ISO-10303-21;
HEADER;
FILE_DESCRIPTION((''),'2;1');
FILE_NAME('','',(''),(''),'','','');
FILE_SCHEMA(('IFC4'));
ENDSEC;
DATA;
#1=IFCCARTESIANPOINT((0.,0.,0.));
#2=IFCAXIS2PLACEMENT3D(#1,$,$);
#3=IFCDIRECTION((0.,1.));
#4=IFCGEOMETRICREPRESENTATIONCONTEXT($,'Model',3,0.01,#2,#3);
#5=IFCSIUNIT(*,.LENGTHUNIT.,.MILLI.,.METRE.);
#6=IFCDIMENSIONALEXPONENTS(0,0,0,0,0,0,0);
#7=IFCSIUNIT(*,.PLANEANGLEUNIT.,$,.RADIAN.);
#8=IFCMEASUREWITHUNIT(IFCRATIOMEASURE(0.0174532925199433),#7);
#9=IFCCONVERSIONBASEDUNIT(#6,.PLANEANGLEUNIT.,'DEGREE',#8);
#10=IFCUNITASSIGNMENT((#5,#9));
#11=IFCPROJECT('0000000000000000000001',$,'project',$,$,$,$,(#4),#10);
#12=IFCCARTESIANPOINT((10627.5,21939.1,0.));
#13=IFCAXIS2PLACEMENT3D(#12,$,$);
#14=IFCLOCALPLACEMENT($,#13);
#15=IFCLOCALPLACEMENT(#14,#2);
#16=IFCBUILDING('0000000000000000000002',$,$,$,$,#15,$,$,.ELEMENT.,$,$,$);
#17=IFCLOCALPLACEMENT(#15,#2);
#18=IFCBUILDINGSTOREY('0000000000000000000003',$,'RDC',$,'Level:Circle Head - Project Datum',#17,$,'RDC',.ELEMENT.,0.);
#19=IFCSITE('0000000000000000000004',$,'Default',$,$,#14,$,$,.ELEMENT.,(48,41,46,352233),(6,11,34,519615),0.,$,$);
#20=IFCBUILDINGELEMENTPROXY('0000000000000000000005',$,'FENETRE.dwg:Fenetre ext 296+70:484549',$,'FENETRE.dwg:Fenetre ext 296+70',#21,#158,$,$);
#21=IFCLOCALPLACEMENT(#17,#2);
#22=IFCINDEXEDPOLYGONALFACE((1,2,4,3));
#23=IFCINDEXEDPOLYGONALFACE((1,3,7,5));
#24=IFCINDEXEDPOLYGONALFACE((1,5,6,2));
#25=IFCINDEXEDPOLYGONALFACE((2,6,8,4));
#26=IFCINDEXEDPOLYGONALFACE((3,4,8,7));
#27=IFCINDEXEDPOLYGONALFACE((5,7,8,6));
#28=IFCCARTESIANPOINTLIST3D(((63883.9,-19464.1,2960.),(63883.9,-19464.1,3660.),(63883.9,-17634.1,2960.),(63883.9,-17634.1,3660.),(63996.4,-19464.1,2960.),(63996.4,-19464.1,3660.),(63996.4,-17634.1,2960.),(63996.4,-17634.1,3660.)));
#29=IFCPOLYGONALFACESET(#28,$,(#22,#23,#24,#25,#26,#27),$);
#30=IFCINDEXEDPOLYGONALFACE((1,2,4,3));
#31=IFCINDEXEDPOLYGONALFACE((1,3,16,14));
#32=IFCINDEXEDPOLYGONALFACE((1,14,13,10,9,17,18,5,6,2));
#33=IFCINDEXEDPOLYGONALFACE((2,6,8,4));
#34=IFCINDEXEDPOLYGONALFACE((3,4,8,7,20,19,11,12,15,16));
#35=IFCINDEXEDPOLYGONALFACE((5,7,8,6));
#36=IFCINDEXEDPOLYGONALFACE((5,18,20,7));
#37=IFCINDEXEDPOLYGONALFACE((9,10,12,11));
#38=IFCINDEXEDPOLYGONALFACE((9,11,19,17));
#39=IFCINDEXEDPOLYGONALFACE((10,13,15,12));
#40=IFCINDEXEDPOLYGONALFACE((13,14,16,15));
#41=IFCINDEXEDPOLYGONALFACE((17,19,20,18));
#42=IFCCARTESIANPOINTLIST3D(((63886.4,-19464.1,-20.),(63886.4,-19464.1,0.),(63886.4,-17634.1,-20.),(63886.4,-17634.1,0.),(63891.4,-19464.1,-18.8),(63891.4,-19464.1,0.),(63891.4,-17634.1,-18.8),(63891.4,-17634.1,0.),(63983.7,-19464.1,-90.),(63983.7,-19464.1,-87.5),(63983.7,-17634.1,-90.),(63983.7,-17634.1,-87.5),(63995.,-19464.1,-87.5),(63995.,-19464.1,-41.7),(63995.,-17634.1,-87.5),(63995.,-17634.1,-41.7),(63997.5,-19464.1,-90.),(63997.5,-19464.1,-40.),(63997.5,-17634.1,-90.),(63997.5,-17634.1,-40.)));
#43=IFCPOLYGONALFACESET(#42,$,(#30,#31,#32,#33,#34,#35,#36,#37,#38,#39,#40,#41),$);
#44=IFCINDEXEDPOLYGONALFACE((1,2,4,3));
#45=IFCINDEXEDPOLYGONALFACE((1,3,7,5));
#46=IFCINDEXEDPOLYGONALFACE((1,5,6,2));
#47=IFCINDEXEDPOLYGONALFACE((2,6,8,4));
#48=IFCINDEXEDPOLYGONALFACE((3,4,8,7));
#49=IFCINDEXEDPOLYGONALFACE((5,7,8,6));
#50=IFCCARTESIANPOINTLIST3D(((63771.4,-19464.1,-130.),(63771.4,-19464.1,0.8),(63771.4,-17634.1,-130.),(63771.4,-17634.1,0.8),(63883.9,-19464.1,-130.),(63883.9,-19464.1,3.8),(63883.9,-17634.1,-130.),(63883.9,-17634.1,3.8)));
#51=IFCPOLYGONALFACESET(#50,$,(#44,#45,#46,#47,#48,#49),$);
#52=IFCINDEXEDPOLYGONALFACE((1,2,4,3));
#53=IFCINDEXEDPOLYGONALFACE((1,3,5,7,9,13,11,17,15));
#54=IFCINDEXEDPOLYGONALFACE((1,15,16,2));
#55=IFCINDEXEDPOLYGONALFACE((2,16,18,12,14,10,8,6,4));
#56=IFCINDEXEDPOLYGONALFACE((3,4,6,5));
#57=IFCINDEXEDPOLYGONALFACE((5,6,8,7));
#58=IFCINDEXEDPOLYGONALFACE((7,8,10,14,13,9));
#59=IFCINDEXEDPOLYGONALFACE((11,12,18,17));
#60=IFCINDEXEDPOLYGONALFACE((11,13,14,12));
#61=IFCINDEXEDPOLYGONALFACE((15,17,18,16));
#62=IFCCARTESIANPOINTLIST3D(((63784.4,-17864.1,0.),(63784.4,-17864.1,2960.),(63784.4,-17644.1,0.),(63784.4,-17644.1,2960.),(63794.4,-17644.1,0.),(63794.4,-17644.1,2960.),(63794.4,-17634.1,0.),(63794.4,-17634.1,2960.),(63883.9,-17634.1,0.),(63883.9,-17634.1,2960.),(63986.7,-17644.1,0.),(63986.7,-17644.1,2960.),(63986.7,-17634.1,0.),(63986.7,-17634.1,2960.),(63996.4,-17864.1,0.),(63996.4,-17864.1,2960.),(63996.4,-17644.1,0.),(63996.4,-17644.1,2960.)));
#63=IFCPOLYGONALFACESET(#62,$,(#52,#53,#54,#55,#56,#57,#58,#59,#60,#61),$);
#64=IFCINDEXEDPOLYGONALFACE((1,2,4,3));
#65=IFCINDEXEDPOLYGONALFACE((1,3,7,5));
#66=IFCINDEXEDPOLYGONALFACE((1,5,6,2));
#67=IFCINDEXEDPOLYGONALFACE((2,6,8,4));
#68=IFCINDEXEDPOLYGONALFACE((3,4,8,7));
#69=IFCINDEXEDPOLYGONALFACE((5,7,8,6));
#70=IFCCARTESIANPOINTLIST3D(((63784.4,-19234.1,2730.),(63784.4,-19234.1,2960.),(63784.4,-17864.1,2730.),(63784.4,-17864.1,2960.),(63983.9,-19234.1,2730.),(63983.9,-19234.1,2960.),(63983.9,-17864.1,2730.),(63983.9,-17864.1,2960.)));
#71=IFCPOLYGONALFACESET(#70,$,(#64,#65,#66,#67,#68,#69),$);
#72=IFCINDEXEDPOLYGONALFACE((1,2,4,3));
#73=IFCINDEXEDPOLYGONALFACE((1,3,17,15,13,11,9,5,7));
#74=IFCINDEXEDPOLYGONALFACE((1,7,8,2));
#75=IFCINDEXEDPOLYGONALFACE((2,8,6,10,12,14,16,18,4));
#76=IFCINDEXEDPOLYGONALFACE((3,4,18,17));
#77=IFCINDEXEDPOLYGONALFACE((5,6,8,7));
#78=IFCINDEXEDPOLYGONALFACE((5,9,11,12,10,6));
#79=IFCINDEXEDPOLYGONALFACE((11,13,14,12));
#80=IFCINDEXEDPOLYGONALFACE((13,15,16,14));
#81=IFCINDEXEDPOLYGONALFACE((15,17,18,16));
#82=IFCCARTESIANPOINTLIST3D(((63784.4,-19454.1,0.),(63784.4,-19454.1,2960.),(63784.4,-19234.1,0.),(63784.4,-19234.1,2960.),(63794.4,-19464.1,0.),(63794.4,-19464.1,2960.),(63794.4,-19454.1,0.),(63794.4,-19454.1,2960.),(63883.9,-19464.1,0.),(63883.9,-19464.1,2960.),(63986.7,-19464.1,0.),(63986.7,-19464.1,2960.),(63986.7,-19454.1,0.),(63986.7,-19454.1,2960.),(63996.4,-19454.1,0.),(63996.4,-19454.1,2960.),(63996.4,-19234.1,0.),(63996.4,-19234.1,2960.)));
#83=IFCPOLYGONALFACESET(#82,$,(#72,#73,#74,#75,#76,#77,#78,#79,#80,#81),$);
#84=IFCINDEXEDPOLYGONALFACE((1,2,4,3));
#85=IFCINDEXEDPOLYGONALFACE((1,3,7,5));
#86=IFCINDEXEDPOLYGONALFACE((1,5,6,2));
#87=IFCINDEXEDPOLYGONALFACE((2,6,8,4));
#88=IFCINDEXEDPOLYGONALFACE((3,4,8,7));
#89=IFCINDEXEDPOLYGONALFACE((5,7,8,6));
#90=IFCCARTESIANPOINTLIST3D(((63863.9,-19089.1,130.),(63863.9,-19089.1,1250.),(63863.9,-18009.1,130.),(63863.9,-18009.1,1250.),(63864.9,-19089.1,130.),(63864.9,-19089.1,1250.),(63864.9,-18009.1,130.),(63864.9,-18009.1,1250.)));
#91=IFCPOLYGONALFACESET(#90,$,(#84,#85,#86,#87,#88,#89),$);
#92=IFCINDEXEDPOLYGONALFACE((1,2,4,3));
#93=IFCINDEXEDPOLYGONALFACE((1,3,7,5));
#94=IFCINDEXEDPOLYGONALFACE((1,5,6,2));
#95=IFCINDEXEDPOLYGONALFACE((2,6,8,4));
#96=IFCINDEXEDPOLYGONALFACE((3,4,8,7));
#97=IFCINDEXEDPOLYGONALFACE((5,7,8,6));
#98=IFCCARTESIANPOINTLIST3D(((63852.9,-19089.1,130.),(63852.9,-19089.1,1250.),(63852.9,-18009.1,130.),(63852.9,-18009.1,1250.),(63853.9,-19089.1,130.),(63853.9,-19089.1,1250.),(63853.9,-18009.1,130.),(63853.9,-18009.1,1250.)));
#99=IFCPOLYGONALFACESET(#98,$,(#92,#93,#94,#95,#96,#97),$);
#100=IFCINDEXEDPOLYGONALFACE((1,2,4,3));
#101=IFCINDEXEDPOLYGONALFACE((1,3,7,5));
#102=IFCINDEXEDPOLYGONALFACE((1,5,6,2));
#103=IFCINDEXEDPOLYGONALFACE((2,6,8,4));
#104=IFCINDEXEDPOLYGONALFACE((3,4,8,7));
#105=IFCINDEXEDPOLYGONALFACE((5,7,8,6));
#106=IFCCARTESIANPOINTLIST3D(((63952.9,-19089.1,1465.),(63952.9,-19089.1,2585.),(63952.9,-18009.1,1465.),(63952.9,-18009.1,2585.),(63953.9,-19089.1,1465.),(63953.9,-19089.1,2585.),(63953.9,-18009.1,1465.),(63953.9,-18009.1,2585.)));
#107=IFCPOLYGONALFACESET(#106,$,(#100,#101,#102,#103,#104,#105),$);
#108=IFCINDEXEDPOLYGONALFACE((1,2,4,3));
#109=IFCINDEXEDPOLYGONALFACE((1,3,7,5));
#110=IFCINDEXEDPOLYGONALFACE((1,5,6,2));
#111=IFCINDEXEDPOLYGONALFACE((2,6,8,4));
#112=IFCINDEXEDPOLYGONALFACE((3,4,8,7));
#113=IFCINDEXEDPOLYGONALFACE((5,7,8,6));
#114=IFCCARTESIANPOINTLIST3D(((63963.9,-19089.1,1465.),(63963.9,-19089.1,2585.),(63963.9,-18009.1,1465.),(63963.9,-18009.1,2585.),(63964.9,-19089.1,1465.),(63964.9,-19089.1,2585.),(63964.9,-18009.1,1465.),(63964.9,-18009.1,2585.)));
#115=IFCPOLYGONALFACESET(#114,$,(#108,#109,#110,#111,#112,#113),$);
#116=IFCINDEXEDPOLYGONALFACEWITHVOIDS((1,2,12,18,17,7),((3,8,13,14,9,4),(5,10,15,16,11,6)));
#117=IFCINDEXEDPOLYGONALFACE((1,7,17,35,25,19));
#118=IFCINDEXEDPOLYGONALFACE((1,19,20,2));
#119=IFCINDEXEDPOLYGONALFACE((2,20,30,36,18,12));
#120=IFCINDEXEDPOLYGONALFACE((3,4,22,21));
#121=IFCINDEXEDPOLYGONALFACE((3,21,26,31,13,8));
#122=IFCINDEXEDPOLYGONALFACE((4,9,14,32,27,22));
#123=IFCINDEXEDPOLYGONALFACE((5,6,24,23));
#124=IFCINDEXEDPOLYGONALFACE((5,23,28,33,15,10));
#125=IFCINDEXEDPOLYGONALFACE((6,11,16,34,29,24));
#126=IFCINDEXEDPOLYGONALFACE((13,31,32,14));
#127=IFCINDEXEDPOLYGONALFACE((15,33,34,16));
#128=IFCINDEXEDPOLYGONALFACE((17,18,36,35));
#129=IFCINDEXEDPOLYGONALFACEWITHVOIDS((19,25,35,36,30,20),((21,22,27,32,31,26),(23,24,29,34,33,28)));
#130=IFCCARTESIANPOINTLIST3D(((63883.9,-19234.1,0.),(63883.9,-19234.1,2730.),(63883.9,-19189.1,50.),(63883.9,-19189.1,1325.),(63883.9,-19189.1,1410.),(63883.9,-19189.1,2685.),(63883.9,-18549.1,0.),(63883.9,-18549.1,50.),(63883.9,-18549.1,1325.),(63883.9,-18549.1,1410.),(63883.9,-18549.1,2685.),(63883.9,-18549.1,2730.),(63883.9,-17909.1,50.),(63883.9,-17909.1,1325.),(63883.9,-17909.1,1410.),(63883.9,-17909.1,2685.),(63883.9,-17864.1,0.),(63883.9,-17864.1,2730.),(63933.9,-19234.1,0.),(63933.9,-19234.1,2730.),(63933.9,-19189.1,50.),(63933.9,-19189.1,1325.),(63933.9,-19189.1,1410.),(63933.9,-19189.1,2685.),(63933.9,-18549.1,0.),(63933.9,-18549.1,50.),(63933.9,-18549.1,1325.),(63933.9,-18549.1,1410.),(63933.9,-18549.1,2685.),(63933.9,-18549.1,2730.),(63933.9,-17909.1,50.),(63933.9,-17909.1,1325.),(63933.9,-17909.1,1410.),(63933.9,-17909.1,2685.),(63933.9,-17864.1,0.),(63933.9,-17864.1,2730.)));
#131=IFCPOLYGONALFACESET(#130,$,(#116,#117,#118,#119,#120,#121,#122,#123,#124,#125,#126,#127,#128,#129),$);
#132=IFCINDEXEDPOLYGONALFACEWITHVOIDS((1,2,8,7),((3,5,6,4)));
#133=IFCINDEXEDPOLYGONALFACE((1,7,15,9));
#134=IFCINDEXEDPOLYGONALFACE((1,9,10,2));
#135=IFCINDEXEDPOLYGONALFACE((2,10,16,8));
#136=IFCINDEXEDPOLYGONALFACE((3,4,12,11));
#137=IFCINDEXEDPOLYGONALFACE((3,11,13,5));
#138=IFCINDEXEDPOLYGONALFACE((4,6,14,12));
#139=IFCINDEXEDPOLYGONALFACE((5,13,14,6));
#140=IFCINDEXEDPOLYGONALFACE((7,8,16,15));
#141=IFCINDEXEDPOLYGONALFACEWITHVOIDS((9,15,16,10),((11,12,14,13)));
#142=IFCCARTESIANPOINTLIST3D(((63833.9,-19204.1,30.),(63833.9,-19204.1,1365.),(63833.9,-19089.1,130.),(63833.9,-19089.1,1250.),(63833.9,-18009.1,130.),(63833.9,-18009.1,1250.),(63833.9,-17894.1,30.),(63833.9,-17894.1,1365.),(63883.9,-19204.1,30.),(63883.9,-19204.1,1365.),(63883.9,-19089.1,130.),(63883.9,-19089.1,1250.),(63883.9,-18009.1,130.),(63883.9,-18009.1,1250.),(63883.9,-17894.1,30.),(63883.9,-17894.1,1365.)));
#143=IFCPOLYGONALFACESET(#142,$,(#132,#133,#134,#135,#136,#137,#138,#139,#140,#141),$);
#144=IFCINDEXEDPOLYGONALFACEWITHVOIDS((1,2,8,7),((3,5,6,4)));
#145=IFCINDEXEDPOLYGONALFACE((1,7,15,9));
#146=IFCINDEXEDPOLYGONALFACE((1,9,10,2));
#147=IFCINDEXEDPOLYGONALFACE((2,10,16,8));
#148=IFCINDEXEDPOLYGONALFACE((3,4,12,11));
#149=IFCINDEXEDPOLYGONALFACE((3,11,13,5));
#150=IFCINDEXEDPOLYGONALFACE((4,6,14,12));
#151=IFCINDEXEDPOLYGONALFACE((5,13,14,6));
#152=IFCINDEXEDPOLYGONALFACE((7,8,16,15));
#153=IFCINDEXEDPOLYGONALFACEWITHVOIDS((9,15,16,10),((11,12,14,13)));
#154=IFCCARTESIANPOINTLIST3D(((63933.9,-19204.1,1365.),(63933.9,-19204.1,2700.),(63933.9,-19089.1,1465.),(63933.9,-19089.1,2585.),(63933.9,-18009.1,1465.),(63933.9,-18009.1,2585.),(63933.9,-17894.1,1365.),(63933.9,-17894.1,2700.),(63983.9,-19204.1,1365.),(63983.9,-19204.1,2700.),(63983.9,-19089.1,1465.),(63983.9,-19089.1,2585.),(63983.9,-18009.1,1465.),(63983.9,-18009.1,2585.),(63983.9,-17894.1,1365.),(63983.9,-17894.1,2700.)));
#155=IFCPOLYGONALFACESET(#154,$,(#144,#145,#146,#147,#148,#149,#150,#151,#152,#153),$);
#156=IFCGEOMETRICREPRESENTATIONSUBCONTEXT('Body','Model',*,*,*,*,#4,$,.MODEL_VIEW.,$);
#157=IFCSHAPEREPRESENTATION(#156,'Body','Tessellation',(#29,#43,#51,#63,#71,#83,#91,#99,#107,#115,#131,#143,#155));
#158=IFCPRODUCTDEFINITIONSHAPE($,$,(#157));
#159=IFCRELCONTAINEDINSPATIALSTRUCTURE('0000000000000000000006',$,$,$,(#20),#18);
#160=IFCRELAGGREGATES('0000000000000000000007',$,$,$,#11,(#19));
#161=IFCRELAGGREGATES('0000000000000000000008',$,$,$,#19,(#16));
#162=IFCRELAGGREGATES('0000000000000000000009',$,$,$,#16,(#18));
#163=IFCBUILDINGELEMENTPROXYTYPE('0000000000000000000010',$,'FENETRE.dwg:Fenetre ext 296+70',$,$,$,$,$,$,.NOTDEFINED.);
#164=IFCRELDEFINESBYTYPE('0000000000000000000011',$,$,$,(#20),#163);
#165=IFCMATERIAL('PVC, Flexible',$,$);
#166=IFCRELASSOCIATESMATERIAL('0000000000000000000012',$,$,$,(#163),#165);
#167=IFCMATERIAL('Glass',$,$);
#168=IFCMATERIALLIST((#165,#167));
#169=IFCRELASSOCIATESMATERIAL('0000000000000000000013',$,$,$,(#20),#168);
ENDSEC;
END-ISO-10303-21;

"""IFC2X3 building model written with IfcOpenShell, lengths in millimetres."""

from ifc_helpers import new_model, entity, si_unit, converted_unit, direction, frame, frame_2d, origin, origin_2d_with_axis, place, context, subcontext, project, spatial, polyline, rectangle, outline, extrude, source, transform, mapped, material, material_list, type_object, type_shapes, element, save


model = new_model("IFC2X3")

# Units and contexts
model_context = context("Model", 3, precision=0.01, world=origin(), true_north=direction((0.0, 1.0)))
body_context = subcontext(model_context, "Body", "Model", "MODEL_VIEW")
ifc_project = project(units=[si_unit("LENGTHUNIT", "METRE", prefix="MILLI"), converted_unit("PLANEANGLEUNIT", "DEGREE", entity("IfcRatioMeasure", 0.0174532925199433), si_unit("PLANEANGLEUNIT", "RADIAN"), dimensions=[0, 0, 0, 0, 0, 0, 0])], contexts=[model_context])

# Site, building, storey
site_placement = place(None, frame((10627.5, 21939.1, 0.0)))
site = spatial("IfcSite", under=ifc_project, at=site_placement, Name="Default", CompositionType="ELEMENT", RefLatitude=(48, 41, 46, 352233), RefLongitude=(6, 11, 34, 519615), RefElevation=0.0)
building_placement = place(site_placement, origin())
building = spatial("IfcBuilding", under=site, at=building_placement, CompositionType="ELEMENT")
storey_placement = place(building_placement, origin())
storey = spatial("IfcBuildingStorey", under=building, at=storey_placement, Name="RDC", ObjectType="Level:Circle Head - Project Datum", LongName="RDC", CompositionType="ELEMENT", Elevation=0.0)

# Building element proxy
ifc_material_1 = material(Name="PVC, Flexible")
ifc_material_2 = material(Name="Glass")
building_element_proxy_type_1 = type_object("IfcBuildingElementProxyType", Name="FENETRE.dwg:Fenetre ext 296+70", PredefinedType="NOTDEFINED", material=ifc_material_1)
shared_shape_1 = source(origin(), body_context, "Body", "SweptSolid", [
    extrude(rectangle(XDim=112.5, YDim=1830.0, at=origin_2d_with_axis()), frame((-10.4, -56.3, 2960.0), z_axis=(0.0, 0.0, 1.0), x_axis=(0.0, 1.0, 0.0)), (0.0, 0.0, 1.0), 700.0),
    extrude(outline(polyline([(27.5, -64.4), (47.5, -64.4), (47.5, -59.4), (28.8, -59.4), (7.5, 46.7), (-42.5, 46.7), (-42.5, 32.9), (-40.0, 32.9), (-40.0, 44.2), (5.8, 44.2), (27.5, -64.4)])), frame((-925.4, -66.9, -47.5), z_axis=(1.0, 0.0, 0.0), x_axis=(0.0, 0.0, 1.0)), (0.0, 0.0, 1.0), 1830.0),
    extrude(outline(polyline([(-54.5, -66.1), (58.0, -66.1), (54.5, 67.6), (-58.0, 64.6), (-54.5, -66.1)])), frame((-925.4, 56.3, -63.8), z_axis=(1.0, 0.0, 0.0), x_axis=(0.0, -0.999645, 0.02665)), (0.0, 0.0, 1.0), 1830.0),
    extrude(outline(polyline([(-97.0, -55.6), (5.9, -55.6), (95.4, -55.6), (95.4, -45.6), (105.4, -45.6), (105.4, 174.4), (-106.6, 174.4), (-106.6, -45.6), (-97.0, -45.6), (-97.0, -55.6)])), frame((849.0, -5.9, 0.0), z_axis=(0.0, 0.0, 1.0), x_axis=(0.0, 1.0, 0.0)), (0.0, 0.0, 1.0), 2960.0),
    extrude(rectangle(XDim=1370.0, YDim=199.5, at=origin_2d_with_axis()), frame((-10.4, -0.3, 2730.0), z_axis=(0.0, 0.0, 1.0), x_axis=(-1.0, 0.0, 0.0)), (0.0, 0.0, 1.0), 230.0),
    extrude(outline(polyline([(-55.6, 97.0), (-55.6, -5.9), (-55.6, -95.4), (-45.6, -95.4), (-45.6, -105.4), (174.4, -105.4), (174.4, 106.6), (-45.6, 106.6), (-45.6, 97.0), (-55.6, 97.0)])), frame((-869.9, -5.9, 0.0), z_axis=(0.0, 0.0, -1.0), x_axis=(1.0, 0.0, 0.0)), (0.0, 0.0, -1.0), 2960.0),
    extrude(rectangle(XDim=1080.0, YDim=1.0, at=origin_2d_with_axis()), frame((-10.4, 19.5, 130.0), z_axis=(0.0, 0.0, 1.0), x_axis=(-1.0, 0.0, 0.0)), (0.0, 0.0, 1.0), 1120.0),
    extrude(rectangle(XDim=1080.0, YDim=1.0, at=origin_2d_with_axis()), frame((-10.4, 30.5, 130.0), z_axis=(0.0, 0.0, 1.0), x_axis=(-1.0, 0.0, 0.0)), (0.0, 0.0, 1.0), 1120.0),
    extrude(rectangle(XDim=1080.0, YDim=1.0, at=frame_2d((0.0, 0.0), x_axis=(1.0, 0.0))), frame((-10.4, -69.5, 1465.0), z_axis=(0.0, 0.0, 1.0), x_axis=(-1.0, 0.0, 0.0)), (0.0, 0.0, 1.0), 1120.0),
    extrude(rectangle(XDim=1080.0, YDim=1.0, at=frame_2d((0.0, 0.0), x_axis=(1.0, 0.0))), frame((-10.4, -80.5, 1465.0), z_axis=(0.0, 0.0, 1.0), x_axis=(-1.0, 0.0, 0.0)), (0.0, 0.0, 1.0), 1120.0),
    extrude(outline(polyline([(-685.0, -1365.0), (0.0, -1365.0), (685.0, -1365.0), (685.0, 1365.0), (0.0, 1365.0), (-685.0, 1365.0), (-685.0, -1365.0)]), holes=[polyline([(-640.0, -1320.0), (-640.0, -45.0), (0.0, -45.0), (640.0, -45.0), (640.0, -1320.0), (0.0, -1320.0), (-640.0, -1320.0)]), polyline([(-640.0, 40.0), (-640.0, 1315.0), (0.0, 1315.0), (640.0, 1315.0), (640.0, 40.0), (0.0, 40.0), (-640.0, 40.0)])]), frame((-10.4, -50.0, 1365.0), z_axis=(0.0, 1.0, 0.0), x_axis=(1.0, 0.0, 0.0)), (0.0, 0.0, 1.0), 50.0),
    extrude(outline(polyline([(-655.0, -667.5), (655.0, -667.5), (655.0, 667.5), (-655.0, 667.5), (-655.0, -667.5)]), holes=[polyline([(-540.0, 552.5), (540.0, 552.5), (540.0, -567.5), (-540.0, -567.5), (-540.0, 552.5)])]), frame((-10.4, 0.0, 697.5), z_axis=(0.0, 1.0, 0.0), x_axis=(-1.0, 0.0, 0.0)), (0.0, 0.0, 1.0), 50.0),
    extrude(outline(polyline([(-655.0, -667.5), (655.0, -667.5), (655.0, 667.5), (-655.0, 667.5), (-655.0, -667.5)]), holes=[polyline([(-540.0, 552.5), (540.0, 552.5), (540.0, -567.5), (-540.0, -567.5), (-540.0, 552.5)])]), frame((-10.4, -100.0, 2032.5), z_axis=(0.0, 1.0, 0.0), x_axis=(-1.0, 0.0, 0.0)), (0.0, 0.0, 1.0), 50.0),
])
type_shapes(building_element_proxy_type_1, [shared_shape_1])
ifc_material_list_1 = material_list([ifc_material_1, ifc_material_2])
proxy_1_placement = place(storey_placement, frame((63883.9, -18538.7, 0.0), z_axis=(0.0, 0.0, 1.0), x_axis=(0.0, 1.0, 0.0)))
element("IfcBuildingElementProxy", 1, at=proxy_1_placement, inside=storey, type_object=building_element_proxy_type_1, material=ifc_material_list_1, Name="FENETRE.dwg:Fenetre ext 296+70:484549", ObjectType="FENETRE.dwg:Fenetre ext 296+70", context=body_context, shape_type="MappedRepresentation", body=[
    mapped(shared_shape_1, transform((0.0, 0.0, 0.0), scale=1.0)),
])

save(model, "model.ifc")
